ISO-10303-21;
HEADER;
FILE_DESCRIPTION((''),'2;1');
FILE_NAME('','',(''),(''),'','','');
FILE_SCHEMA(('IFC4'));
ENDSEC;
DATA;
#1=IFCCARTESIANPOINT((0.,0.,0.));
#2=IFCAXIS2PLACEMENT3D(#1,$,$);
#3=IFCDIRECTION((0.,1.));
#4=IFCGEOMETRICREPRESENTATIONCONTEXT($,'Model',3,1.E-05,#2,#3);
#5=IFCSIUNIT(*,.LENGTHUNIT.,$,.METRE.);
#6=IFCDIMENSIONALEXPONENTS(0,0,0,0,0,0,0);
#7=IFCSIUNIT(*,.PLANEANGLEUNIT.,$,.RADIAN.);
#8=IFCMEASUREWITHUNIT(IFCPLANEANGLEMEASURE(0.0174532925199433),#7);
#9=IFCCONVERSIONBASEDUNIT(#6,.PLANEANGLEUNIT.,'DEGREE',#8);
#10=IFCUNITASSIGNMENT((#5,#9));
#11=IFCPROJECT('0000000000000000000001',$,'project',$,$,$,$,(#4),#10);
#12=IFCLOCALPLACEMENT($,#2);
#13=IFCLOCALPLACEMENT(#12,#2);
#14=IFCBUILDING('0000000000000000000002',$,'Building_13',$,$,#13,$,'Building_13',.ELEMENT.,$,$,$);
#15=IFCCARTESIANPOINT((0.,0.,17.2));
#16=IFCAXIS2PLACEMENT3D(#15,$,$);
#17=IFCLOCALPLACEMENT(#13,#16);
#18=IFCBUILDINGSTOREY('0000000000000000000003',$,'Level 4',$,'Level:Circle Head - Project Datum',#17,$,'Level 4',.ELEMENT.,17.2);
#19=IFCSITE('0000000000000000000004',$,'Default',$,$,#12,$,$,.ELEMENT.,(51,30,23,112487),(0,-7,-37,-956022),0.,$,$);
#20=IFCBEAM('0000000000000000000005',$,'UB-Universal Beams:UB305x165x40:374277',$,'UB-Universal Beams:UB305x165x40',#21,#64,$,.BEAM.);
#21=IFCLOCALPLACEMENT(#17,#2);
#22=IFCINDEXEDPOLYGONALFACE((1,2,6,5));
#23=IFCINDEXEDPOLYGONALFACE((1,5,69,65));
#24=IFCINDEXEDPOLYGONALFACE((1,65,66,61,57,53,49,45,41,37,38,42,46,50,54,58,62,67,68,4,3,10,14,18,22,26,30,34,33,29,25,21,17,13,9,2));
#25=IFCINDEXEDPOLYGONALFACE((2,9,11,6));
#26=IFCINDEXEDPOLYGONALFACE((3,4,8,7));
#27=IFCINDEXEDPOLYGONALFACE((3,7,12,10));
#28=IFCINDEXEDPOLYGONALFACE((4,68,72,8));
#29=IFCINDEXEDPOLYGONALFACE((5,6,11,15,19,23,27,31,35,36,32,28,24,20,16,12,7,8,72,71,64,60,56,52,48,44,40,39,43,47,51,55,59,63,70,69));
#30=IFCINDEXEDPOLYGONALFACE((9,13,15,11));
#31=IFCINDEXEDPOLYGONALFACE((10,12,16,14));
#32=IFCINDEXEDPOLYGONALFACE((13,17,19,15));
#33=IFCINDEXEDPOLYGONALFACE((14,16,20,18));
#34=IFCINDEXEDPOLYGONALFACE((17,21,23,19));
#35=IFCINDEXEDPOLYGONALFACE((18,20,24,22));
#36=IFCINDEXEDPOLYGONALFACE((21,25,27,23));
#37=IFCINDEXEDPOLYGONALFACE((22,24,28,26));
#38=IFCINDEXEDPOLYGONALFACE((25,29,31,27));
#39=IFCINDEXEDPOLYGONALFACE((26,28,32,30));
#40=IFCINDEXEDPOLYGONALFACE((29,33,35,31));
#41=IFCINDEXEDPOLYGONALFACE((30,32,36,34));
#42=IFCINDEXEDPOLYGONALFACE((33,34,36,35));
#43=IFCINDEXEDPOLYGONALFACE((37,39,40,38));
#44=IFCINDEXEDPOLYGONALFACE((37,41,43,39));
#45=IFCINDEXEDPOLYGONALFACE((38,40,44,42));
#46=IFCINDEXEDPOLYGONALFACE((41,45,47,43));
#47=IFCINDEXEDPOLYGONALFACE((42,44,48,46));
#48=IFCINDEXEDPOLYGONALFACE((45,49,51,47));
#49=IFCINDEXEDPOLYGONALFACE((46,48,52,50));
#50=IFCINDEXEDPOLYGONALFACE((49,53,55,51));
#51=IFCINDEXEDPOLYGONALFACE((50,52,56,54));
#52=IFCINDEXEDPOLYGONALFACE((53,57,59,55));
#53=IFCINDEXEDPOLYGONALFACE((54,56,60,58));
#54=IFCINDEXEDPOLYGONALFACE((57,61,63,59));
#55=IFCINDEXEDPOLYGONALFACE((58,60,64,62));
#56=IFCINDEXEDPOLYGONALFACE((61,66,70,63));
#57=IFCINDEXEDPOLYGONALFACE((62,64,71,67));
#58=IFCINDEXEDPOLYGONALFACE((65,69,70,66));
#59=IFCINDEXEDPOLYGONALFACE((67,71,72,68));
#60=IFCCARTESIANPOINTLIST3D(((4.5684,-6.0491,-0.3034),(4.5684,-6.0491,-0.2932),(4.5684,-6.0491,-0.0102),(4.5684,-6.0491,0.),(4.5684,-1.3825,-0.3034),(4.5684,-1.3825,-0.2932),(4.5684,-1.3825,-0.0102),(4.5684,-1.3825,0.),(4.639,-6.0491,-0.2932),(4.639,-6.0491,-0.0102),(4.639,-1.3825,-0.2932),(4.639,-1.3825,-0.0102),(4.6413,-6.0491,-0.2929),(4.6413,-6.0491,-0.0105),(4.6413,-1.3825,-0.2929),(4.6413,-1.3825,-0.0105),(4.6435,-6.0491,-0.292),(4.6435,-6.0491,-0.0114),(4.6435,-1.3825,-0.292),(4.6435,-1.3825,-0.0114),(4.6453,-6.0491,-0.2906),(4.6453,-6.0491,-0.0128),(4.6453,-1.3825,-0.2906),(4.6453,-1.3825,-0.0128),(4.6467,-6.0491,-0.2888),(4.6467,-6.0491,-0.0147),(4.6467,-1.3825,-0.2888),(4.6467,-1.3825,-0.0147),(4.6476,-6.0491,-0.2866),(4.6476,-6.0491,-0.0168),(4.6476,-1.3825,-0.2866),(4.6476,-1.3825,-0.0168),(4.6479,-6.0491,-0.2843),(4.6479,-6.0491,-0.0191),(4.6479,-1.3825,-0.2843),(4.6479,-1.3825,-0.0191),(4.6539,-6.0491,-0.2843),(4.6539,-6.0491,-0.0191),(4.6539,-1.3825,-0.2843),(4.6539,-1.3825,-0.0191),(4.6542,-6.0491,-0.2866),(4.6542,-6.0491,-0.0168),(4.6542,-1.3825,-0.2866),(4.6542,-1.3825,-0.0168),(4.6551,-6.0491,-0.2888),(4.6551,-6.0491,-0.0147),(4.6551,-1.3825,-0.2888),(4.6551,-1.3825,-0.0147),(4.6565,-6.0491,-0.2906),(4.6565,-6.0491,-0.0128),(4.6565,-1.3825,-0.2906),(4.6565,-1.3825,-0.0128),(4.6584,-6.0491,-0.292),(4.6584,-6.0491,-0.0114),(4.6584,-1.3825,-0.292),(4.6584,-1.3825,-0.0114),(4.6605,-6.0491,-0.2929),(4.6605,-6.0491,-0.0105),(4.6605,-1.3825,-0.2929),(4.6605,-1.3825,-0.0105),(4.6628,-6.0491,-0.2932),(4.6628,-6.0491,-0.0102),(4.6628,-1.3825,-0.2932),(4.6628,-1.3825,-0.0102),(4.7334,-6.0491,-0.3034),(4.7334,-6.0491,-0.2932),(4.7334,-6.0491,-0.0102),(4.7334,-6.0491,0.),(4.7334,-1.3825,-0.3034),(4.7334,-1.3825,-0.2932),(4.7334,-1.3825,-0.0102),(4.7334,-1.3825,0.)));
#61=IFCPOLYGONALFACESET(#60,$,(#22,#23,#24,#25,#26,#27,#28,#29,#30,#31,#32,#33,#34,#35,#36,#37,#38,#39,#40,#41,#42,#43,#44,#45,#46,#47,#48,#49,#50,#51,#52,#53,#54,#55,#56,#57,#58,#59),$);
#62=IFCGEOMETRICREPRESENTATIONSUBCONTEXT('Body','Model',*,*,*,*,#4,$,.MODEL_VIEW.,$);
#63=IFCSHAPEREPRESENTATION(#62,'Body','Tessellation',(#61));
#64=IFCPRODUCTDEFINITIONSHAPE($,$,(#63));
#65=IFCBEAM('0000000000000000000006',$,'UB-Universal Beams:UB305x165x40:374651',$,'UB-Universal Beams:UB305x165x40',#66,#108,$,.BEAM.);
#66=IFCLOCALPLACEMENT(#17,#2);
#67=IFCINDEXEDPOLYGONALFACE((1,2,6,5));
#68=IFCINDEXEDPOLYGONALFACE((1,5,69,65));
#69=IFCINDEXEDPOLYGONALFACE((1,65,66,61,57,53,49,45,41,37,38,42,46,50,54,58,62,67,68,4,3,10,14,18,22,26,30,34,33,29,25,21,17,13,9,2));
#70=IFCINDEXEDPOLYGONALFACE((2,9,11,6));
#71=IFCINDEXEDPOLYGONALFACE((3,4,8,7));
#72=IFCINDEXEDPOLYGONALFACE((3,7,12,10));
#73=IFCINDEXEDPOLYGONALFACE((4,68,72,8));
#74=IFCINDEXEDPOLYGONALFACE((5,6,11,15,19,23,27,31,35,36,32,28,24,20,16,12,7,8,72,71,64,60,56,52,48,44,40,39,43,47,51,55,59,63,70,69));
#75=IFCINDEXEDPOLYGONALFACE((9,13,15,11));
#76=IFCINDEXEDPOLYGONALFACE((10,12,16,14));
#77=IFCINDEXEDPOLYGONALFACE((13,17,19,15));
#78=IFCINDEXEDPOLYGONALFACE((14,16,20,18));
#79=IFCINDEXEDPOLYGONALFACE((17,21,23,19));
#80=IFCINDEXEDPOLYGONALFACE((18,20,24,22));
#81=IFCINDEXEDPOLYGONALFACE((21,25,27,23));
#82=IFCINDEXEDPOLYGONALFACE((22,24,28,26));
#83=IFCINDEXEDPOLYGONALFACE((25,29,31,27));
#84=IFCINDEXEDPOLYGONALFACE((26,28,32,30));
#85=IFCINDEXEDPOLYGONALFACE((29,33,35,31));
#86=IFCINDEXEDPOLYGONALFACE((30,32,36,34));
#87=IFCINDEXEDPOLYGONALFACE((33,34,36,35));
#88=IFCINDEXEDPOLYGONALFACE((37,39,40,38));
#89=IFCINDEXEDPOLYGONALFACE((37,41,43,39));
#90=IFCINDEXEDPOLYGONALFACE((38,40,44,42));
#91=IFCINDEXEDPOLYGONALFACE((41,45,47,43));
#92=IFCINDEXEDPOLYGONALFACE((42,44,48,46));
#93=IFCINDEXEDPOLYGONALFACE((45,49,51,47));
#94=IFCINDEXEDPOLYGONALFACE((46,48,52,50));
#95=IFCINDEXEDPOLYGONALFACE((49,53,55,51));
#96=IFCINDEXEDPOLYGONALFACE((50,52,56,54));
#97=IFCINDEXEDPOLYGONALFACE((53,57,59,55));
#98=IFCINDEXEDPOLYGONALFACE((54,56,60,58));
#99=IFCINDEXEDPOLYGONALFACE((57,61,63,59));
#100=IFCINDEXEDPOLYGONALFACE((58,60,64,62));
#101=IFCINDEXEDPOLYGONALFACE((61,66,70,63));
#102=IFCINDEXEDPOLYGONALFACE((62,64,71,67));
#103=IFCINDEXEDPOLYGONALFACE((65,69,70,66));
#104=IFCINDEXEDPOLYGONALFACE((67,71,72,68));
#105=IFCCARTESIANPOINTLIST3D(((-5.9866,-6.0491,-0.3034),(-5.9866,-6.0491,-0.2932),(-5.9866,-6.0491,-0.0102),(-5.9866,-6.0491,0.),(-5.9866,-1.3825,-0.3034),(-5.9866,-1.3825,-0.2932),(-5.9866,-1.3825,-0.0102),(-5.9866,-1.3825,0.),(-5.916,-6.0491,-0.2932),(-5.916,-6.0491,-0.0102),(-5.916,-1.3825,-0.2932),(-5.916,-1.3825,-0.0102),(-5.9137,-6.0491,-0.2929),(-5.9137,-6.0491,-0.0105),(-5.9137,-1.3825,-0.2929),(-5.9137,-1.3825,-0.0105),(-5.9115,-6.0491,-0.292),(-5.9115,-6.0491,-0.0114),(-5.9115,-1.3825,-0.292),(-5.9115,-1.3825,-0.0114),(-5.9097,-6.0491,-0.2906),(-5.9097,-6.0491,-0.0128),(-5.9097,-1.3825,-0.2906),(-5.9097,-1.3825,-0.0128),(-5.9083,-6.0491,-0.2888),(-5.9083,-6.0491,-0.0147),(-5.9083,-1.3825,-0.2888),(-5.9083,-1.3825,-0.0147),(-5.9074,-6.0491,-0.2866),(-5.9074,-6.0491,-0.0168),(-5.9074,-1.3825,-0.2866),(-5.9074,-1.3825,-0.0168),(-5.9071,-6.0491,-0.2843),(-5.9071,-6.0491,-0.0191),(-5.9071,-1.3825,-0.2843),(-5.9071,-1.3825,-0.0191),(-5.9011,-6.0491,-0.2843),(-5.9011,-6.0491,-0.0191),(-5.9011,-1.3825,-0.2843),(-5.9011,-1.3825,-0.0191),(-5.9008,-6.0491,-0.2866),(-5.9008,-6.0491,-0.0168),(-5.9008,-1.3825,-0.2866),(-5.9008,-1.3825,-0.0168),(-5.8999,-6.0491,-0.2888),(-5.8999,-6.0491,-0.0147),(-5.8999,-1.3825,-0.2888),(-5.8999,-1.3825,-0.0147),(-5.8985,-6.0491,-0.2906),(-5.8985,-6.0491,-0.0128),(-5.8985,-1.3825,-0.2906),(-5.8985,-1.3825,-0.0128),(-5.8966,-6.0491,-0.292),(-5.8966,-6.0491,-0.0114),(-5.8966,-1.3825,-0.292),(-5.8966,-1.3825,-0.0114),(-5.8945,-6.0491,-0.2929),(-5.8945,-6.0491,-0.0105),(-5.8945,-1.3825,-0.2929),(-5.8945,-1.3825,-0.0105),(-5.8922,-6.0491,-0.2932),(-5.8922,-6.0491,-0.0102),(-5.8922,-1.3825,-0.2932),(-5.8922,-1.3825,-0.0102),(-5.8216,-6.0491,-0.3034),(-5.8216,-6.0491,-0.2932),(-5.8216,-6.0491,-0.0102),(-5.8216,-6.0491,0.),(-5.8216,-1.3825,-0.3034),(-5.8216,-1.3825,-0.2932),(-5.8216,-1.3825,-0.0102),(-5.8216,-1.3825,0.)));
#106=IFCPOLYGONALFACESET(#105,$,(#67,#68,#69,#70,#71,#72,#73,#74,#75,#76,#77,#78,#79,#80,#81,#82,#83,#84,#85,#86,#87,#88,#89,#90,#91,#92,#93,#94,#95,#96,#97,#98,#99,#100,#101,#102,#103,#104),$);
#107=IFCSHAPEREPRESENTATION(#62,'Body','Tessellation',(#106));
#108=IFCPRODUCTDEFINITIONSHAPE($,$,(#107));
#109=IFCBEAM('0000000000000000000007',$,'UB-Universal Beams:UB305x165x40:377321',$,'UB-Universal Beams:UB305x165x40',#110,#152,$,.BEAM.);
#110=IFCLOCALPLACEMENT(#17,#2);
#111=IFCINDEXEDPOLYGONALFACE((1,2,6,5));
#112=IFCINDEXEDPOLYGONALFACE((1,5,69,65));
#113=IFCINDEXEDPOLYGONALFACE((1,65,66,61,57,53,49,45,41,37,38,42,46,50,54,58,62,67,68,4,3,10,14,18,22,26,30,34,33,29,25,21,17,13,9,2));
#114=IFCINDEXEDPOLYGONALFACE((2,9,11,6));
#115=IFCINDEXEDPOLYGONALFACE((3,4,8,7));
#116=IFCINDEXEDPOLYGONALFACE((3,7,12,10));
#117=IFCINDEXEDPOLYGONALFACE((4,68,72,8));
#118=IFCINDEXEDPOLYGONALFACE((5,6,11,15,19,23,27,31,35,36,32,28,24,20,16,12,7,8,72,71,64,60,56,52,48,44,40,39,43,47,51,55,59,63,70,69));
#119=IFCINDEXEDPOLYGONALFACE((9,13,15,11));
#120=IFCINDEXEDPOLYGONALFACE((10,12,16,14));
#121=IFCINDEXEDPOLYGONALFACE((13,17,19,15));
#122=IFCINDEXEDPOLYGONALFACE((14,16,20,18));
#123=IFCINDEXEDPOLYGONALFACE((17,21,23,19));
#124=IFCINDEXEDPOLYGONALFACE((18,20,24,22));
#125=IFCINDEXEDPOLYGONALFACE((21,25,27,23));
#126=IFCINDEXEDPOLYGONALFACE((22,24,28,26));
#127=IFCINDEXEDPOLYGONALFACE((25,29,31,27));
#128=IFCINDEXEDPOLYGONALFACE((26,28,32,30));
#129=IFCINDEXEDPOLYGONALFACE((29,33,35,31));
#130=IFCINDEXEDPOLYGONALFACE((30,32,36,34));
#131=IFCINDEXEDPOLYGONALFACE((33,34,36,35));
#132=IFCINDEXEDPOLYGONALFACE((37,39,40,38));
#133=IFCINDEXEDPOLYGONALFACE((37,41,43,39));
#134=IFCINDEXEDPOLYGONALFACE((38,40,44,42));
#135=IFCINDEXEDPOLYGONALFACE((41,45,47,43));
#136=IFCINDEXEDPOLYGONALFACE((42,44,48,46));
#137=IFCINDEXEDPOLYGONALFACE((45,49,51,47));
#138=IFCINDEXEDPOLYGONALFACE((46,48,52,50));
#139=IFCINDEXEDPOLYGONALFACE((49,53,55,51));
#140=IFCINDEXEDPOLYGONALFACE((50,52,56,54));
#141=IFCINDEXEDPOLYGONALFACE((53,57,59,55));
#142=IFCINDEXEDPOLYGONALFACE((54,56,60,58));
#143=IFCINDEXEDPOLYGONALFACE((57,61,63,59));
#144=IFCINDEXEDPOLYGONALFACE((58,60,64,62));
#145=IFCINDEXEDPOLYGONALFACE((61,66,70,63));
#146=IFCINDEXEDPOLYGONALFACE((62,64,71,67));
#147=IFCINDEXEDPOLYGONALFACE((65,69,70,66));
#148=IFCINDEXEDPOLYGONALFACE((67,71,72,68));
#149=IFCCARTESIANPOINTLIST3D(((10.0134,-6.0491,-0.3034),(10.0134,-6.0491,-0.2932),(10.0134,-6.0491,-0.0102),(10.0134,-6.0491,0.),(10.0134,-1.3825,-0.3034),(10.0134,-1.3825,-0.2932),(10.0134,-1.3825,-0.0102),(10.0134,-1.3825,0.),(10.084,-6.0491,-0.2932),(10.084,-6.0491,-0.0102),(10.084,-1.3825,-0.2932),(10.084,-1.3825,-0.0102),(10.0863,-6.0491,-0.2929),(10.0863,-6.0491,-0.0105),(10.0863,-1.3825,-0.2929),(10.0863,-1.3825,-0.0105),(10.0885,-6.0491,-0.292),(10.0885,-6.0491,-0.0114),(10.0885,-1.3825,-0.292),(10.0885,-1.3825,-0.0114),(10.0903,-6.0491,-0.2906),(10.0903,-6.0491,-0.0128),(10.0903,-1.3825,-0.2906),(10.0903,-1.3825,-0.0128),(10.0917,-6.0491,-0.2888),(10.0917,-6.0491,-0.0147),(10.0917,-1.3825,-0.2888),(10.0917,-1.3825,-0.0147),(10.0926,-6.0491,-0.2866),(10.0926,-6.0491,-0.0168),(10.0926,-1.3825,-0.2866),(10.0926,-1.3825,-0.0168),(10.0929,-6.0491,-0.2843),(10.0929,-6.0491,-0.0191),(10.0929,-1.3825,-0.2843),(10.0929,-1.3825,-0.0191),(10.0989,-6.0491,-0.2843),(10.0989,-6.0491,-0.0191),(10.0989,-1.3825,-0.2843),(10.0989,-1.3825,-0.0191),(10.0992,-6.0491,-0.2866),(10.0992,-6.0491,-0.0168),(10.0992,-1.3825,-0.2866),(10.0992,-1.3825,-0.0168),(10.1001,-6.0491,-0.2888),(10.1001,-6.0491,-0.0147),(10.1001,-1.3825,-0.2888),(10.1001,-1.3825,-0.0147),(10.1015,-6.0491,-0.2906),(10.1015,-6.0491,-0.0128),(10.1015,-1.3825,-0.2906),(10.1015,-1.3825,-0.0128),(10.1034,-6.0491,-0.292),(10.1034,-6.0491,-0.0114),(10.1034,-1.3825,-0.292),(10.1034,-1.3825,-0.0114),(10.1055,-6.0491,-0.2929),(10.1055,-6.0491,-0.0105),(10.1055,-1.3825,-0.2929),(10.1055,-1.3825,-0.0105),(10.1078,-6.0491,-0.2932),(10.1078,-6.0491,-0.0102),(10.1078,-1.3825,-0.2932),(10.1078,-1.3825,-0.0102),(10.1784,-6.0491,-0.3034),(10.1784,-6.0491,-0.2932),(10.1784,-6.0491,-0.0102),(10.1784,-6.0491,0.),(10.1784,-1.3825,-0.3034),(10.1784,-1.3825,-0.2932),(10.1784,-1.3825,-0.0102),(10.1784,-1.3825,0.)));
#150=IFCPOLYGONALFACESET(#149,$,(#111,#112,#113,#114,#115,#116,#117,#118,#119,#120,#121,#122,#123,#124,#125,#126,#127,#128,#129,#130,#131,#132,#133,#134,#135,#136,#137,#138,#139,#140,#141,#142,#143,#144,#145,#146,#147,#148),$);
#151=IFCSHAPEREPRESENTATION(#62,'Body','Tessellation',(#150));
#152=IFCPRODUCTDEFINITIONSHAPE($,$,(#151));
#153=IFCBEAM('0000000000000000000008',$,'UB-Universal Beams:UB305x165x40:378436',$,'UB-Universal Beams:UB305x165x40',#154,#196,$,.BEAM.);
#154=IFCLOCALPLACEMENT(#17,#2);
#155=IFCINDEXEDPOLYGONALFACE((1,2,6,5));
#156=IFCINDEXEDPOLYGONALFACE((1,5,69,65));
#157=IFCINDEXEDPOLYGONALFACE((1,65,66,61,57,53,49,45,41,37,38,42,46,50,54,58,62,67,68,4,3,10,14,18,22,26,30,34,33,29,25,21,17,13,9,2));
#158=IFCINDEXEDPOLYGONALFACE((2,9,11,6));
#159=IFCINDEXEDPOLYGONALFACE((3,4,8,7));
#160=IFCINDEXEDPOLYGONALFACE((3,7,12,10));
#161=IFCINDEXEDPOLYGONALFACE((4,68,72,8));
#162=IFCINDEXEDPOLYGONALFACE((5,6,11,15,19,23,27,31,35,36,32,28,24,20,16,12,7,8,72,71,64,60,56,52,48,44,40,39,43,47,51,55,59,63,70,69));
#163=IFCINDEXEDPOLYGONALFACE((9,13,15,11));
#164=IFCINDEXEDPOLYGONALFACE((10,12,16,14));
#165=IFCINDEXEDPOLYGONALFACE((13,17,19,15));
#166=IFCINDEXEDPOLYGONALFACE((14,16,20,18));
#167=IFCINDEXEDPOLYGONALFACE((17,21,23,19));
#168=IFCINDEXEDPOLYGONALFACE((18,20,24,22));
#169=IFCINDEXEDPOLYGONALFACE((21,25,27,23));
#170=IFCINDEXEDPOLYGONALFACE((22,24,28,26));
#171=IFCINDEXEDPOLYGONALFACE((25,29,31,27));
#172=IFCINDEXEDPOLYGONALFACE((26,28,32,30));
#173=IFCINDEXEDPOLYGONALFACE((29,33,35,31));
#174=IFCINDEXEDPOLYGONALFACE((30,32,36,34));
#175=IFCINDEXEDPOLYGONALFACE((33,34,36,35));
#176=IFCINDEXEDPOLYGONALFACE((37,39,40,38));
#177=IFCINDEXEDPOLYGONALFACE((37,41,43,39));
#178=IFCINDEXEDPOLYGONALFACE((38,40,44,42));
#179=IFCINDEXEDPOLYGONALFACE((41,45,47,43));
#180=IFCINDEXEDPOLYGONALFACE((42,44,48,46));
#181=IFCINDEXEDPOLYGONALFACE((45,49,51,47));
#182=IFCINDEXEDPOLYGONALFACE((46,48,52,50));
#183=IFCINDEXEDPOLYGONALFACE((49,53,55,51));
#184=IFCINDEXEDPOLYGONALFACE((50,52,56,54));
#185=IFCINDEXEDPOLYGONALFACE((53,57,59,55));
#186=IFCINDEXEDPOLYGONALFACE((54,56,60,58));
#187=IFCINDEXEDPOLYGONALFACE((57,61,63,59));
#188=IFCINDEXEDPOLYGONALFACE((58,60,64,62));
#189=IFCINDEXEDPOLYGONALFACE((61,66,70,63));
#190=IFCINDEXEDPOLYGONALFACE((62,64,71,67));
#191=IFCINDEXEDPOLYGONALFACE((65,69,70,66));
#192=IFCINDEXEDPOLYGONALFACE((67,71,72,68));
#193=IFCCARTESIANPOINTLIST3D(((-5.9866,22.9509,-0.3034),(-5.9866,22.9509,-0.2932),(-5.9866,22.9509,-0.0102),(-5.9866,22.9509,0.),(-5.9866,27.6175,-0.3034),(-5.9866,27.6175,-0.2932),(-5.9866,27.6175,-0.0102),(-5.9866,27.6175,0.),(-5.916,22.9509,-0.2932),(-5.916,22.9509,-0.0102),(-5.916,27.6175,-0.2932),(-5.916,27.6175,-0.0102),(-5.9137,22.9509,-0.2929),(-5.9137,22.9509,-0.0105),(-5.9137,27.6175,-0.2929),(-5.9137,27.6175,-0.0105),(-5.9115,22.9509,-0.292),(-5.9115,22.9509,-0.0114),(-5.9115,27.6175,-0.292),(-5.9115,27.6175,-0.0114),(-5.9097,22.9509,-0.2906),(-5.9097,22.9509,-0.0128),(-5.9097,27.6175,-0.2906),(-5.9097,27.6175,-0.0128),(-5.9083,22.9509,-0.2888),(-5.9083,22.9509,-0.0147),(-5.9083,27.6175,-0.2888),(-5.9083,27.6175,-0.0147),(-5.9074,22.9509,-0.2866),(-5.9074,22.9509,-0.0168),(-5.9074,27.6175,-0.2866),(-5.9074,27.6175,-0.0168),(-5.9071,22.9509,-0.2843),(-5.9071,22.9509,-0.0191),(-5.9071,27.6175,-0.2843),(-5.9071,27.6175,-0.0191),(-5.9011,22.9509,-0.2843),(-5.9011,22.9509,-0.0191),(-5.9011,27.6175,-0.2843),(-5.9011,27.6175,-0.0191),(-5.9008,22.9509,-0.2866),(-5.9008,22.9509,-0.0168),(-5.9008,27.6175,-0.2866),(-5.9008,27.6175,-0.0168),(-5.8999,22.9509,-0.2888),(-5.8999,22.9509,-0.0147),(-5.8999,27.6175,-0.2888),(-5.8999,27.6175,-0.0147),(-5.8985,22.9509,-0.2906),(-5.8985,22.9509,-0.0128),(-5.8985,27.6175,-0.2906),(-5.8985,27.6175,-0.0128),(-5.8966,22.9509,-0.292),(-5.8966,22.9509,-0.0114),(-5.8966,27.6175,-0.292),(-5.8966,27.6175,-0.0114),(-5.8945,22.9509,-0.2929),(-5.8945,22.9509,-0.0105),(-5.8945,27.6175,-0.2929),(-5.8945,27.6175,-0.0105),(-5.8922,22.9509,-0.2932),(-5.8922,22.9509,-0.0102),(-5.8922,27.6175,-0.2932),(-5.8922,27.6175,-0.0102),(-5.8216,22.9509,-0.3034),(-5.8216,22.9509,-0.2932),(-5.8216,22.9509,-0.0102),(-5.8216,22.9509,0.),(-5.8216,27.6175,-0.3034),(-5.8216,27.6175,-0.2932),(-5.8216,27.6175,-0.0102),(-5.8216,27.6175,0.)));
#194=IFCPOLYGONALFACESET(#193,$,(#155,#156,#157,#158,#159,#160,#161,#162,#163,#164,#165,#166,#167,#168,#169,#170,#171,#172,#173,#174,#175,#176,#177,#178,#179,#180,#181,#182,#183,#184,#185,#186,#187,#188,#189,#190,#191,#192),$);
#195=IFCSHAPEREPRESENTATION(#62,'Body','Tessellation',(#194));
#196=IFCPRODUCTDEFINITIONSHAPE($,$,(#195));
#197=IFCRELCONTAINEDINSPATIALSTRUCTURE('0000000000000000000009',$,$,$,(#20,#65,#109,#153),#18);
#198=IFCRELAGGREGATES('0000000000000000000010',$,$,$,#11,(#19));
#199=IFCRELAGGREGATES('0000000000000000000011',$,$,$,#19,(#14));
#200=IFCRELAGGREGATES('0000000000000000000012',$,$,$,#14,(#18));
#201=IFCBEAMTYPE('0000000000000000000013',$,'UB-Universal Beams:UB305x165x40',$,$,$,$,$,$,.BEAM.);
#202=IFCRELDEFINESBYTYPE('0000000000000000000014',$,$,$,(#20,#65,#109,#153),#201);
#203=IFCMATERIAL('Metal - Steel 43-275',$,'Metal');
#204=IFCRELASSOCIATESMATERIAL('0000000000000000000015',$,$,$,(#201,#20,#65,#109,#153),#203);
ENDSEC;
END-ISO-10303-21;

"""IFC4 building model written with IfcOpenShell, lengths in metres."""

from ifc_helpers import new_model, entity, si_unit, converted_unit, direction, frame, origin, place, context, subcontext, project, spatial, line, arc, indexed_curve, outline, extrude, source, transform, mapped, material, type_object, type_shapes, element, save


model = new_model("IFC4")

# Units and contexts
model_context = context("Model", 3, precision=1e-05, world=origin(), true_north=direction((0.0, 1.0)))
body_context = subcontext(model_context, "Body", "Model", "MODEL_VIEW")
ifc_project = project(units=[si_unit("LENGTHUNIT", "METRE"), converted_unit("PLANEANGLEUNIT", "DEGREE", entity("IfcPlaneAngleMeasure", 0.0174532925199433), si_unit("PLANEANGLEUNIT", "RADIAN"), dimensions=[0, 0, 0, 0, 0, 0, 0])], contexts=[model_context])

# Site, building, storey
site_placement = place(None, origin())
site = spatial("IfcSite", under=ifc_project, at=site_placement, Name="Default", CompositionType="ELEMENT", RefLatitude=(51, 30, 23, 112487), RefLongitude=(0, -7, -37, -956022), RefElevation=0.0)
building_placement = place(site_placement, origin())
building = spatial("IfcBuilding", under=site, at=building_placement, Name="Building_13", LongName="Building_13", CompositionType="ELEMENT")
storey_placement = place(building_placement, frame((0.0, 0.0, 17.2)))
storey = spatial("IfcBuildingStorey", under=building, at=storey_placement, Name="Level 4", ObjectType="Level:Circle Head - Project Datum", LongName="Level 4", CompositionType="ELEMENT", Elevation=17.2)

# Beams
ifc_material_1 = material(Name="Metal - Steel 43-275", Category="Metal")
beam_type_1 = type_object("IfcBeamType", Name="UB-Universal Beams:UB305x165x40", PredefinedType="BEAM", material=ifc_material_1)
shared_shape_1 = source(origin(), body_context, "Body", "SweptSolid", [
    extrude(outline(indexed_curve([(-0.0825, -0.1415), (-0.0825, -0.1517), (0.0825, -0.1517), (0.0825, -0.1415), (0.0119, -0.1415), (0.0056, -0.1389), (0.003, -0.1326), (0.003, 0.1326), (0.0056, 0.1389), (0.0119, 0.1415), (0.0825, 0.1415), (0.0825, 0.1517), (-0.0825, 0.1517), (-0.0825, 0.1415), (-0.0119, 0.1415), (-0.0056, 0.1389), (-0.003, 0.1326), (-0.003, -0.1326), (-0.0056, -0.1389), (-0.0119, -0.1415)], segments=[line(1, 2, 3, 4, 5), arc(5, 6, 7), line(7, 8), arc(8, 9, 10), line(10, 11, 12, 13, 14, 15), arc(15, 16, 17), line(17, 18), arc(18, 19, 20), line(20, 1)], self_intersect=False)), frame((-2.3333, 0.0, 0.0), z_axis=(-1.0, 0.0, 0.0), x_axis=(0.0, -1.0, 0.0)), (0.0, 0.0, -1.0), 4.6666),
])
type_shapes(beam_type_1, [shared_shape_1])
for number, where, z_axis, x_axis, name in (
    (1, (4.6509, -3.7158, -0.1517), (0.0, 0.0, 1.0), (0.0, -1.0, 0.0), "UB-Universal Beams:UB305x165x40:374277"),
    (2, (-5.9041, -3.7158, -0.1517), (0.0, 0.0, 1.0), (0.0, -1.0, 0.0), "UB-Universal Beams:UB305x165x40:374651"),
    (3, (10.0959, -3.7158, -0.1517), (0.0, 0.0, 1.0), (0.0, -1.0, 0.0), "UB-Universal Beams:UB305x165x40:377321"),
    (4, (-5.9041, 25.2842, -0.1517), (0.0, 0.0, 1.0), (0.0, -1.0, 0.0), "UB-Universal Beams:UB305x165x40:378436"),
):
    element("IfcBeam", number, at=place(storey_placement, frame(where, z_axis=z_axis, x_axis=x_axis)), inside=storey, type_object=beam_type_1, material=ifc_material_1, Name=name, ObjectType="UB-Universal Beams:UB305x165x40", PredefinedType="BEAM", context=body_context, shape_type="MappedRepresentation", body=[
        mapped(shared_shape_1, transform((0.0, 0.0, 0.0), scale=1.0)),
    ])

save(model, "model.ifc")
